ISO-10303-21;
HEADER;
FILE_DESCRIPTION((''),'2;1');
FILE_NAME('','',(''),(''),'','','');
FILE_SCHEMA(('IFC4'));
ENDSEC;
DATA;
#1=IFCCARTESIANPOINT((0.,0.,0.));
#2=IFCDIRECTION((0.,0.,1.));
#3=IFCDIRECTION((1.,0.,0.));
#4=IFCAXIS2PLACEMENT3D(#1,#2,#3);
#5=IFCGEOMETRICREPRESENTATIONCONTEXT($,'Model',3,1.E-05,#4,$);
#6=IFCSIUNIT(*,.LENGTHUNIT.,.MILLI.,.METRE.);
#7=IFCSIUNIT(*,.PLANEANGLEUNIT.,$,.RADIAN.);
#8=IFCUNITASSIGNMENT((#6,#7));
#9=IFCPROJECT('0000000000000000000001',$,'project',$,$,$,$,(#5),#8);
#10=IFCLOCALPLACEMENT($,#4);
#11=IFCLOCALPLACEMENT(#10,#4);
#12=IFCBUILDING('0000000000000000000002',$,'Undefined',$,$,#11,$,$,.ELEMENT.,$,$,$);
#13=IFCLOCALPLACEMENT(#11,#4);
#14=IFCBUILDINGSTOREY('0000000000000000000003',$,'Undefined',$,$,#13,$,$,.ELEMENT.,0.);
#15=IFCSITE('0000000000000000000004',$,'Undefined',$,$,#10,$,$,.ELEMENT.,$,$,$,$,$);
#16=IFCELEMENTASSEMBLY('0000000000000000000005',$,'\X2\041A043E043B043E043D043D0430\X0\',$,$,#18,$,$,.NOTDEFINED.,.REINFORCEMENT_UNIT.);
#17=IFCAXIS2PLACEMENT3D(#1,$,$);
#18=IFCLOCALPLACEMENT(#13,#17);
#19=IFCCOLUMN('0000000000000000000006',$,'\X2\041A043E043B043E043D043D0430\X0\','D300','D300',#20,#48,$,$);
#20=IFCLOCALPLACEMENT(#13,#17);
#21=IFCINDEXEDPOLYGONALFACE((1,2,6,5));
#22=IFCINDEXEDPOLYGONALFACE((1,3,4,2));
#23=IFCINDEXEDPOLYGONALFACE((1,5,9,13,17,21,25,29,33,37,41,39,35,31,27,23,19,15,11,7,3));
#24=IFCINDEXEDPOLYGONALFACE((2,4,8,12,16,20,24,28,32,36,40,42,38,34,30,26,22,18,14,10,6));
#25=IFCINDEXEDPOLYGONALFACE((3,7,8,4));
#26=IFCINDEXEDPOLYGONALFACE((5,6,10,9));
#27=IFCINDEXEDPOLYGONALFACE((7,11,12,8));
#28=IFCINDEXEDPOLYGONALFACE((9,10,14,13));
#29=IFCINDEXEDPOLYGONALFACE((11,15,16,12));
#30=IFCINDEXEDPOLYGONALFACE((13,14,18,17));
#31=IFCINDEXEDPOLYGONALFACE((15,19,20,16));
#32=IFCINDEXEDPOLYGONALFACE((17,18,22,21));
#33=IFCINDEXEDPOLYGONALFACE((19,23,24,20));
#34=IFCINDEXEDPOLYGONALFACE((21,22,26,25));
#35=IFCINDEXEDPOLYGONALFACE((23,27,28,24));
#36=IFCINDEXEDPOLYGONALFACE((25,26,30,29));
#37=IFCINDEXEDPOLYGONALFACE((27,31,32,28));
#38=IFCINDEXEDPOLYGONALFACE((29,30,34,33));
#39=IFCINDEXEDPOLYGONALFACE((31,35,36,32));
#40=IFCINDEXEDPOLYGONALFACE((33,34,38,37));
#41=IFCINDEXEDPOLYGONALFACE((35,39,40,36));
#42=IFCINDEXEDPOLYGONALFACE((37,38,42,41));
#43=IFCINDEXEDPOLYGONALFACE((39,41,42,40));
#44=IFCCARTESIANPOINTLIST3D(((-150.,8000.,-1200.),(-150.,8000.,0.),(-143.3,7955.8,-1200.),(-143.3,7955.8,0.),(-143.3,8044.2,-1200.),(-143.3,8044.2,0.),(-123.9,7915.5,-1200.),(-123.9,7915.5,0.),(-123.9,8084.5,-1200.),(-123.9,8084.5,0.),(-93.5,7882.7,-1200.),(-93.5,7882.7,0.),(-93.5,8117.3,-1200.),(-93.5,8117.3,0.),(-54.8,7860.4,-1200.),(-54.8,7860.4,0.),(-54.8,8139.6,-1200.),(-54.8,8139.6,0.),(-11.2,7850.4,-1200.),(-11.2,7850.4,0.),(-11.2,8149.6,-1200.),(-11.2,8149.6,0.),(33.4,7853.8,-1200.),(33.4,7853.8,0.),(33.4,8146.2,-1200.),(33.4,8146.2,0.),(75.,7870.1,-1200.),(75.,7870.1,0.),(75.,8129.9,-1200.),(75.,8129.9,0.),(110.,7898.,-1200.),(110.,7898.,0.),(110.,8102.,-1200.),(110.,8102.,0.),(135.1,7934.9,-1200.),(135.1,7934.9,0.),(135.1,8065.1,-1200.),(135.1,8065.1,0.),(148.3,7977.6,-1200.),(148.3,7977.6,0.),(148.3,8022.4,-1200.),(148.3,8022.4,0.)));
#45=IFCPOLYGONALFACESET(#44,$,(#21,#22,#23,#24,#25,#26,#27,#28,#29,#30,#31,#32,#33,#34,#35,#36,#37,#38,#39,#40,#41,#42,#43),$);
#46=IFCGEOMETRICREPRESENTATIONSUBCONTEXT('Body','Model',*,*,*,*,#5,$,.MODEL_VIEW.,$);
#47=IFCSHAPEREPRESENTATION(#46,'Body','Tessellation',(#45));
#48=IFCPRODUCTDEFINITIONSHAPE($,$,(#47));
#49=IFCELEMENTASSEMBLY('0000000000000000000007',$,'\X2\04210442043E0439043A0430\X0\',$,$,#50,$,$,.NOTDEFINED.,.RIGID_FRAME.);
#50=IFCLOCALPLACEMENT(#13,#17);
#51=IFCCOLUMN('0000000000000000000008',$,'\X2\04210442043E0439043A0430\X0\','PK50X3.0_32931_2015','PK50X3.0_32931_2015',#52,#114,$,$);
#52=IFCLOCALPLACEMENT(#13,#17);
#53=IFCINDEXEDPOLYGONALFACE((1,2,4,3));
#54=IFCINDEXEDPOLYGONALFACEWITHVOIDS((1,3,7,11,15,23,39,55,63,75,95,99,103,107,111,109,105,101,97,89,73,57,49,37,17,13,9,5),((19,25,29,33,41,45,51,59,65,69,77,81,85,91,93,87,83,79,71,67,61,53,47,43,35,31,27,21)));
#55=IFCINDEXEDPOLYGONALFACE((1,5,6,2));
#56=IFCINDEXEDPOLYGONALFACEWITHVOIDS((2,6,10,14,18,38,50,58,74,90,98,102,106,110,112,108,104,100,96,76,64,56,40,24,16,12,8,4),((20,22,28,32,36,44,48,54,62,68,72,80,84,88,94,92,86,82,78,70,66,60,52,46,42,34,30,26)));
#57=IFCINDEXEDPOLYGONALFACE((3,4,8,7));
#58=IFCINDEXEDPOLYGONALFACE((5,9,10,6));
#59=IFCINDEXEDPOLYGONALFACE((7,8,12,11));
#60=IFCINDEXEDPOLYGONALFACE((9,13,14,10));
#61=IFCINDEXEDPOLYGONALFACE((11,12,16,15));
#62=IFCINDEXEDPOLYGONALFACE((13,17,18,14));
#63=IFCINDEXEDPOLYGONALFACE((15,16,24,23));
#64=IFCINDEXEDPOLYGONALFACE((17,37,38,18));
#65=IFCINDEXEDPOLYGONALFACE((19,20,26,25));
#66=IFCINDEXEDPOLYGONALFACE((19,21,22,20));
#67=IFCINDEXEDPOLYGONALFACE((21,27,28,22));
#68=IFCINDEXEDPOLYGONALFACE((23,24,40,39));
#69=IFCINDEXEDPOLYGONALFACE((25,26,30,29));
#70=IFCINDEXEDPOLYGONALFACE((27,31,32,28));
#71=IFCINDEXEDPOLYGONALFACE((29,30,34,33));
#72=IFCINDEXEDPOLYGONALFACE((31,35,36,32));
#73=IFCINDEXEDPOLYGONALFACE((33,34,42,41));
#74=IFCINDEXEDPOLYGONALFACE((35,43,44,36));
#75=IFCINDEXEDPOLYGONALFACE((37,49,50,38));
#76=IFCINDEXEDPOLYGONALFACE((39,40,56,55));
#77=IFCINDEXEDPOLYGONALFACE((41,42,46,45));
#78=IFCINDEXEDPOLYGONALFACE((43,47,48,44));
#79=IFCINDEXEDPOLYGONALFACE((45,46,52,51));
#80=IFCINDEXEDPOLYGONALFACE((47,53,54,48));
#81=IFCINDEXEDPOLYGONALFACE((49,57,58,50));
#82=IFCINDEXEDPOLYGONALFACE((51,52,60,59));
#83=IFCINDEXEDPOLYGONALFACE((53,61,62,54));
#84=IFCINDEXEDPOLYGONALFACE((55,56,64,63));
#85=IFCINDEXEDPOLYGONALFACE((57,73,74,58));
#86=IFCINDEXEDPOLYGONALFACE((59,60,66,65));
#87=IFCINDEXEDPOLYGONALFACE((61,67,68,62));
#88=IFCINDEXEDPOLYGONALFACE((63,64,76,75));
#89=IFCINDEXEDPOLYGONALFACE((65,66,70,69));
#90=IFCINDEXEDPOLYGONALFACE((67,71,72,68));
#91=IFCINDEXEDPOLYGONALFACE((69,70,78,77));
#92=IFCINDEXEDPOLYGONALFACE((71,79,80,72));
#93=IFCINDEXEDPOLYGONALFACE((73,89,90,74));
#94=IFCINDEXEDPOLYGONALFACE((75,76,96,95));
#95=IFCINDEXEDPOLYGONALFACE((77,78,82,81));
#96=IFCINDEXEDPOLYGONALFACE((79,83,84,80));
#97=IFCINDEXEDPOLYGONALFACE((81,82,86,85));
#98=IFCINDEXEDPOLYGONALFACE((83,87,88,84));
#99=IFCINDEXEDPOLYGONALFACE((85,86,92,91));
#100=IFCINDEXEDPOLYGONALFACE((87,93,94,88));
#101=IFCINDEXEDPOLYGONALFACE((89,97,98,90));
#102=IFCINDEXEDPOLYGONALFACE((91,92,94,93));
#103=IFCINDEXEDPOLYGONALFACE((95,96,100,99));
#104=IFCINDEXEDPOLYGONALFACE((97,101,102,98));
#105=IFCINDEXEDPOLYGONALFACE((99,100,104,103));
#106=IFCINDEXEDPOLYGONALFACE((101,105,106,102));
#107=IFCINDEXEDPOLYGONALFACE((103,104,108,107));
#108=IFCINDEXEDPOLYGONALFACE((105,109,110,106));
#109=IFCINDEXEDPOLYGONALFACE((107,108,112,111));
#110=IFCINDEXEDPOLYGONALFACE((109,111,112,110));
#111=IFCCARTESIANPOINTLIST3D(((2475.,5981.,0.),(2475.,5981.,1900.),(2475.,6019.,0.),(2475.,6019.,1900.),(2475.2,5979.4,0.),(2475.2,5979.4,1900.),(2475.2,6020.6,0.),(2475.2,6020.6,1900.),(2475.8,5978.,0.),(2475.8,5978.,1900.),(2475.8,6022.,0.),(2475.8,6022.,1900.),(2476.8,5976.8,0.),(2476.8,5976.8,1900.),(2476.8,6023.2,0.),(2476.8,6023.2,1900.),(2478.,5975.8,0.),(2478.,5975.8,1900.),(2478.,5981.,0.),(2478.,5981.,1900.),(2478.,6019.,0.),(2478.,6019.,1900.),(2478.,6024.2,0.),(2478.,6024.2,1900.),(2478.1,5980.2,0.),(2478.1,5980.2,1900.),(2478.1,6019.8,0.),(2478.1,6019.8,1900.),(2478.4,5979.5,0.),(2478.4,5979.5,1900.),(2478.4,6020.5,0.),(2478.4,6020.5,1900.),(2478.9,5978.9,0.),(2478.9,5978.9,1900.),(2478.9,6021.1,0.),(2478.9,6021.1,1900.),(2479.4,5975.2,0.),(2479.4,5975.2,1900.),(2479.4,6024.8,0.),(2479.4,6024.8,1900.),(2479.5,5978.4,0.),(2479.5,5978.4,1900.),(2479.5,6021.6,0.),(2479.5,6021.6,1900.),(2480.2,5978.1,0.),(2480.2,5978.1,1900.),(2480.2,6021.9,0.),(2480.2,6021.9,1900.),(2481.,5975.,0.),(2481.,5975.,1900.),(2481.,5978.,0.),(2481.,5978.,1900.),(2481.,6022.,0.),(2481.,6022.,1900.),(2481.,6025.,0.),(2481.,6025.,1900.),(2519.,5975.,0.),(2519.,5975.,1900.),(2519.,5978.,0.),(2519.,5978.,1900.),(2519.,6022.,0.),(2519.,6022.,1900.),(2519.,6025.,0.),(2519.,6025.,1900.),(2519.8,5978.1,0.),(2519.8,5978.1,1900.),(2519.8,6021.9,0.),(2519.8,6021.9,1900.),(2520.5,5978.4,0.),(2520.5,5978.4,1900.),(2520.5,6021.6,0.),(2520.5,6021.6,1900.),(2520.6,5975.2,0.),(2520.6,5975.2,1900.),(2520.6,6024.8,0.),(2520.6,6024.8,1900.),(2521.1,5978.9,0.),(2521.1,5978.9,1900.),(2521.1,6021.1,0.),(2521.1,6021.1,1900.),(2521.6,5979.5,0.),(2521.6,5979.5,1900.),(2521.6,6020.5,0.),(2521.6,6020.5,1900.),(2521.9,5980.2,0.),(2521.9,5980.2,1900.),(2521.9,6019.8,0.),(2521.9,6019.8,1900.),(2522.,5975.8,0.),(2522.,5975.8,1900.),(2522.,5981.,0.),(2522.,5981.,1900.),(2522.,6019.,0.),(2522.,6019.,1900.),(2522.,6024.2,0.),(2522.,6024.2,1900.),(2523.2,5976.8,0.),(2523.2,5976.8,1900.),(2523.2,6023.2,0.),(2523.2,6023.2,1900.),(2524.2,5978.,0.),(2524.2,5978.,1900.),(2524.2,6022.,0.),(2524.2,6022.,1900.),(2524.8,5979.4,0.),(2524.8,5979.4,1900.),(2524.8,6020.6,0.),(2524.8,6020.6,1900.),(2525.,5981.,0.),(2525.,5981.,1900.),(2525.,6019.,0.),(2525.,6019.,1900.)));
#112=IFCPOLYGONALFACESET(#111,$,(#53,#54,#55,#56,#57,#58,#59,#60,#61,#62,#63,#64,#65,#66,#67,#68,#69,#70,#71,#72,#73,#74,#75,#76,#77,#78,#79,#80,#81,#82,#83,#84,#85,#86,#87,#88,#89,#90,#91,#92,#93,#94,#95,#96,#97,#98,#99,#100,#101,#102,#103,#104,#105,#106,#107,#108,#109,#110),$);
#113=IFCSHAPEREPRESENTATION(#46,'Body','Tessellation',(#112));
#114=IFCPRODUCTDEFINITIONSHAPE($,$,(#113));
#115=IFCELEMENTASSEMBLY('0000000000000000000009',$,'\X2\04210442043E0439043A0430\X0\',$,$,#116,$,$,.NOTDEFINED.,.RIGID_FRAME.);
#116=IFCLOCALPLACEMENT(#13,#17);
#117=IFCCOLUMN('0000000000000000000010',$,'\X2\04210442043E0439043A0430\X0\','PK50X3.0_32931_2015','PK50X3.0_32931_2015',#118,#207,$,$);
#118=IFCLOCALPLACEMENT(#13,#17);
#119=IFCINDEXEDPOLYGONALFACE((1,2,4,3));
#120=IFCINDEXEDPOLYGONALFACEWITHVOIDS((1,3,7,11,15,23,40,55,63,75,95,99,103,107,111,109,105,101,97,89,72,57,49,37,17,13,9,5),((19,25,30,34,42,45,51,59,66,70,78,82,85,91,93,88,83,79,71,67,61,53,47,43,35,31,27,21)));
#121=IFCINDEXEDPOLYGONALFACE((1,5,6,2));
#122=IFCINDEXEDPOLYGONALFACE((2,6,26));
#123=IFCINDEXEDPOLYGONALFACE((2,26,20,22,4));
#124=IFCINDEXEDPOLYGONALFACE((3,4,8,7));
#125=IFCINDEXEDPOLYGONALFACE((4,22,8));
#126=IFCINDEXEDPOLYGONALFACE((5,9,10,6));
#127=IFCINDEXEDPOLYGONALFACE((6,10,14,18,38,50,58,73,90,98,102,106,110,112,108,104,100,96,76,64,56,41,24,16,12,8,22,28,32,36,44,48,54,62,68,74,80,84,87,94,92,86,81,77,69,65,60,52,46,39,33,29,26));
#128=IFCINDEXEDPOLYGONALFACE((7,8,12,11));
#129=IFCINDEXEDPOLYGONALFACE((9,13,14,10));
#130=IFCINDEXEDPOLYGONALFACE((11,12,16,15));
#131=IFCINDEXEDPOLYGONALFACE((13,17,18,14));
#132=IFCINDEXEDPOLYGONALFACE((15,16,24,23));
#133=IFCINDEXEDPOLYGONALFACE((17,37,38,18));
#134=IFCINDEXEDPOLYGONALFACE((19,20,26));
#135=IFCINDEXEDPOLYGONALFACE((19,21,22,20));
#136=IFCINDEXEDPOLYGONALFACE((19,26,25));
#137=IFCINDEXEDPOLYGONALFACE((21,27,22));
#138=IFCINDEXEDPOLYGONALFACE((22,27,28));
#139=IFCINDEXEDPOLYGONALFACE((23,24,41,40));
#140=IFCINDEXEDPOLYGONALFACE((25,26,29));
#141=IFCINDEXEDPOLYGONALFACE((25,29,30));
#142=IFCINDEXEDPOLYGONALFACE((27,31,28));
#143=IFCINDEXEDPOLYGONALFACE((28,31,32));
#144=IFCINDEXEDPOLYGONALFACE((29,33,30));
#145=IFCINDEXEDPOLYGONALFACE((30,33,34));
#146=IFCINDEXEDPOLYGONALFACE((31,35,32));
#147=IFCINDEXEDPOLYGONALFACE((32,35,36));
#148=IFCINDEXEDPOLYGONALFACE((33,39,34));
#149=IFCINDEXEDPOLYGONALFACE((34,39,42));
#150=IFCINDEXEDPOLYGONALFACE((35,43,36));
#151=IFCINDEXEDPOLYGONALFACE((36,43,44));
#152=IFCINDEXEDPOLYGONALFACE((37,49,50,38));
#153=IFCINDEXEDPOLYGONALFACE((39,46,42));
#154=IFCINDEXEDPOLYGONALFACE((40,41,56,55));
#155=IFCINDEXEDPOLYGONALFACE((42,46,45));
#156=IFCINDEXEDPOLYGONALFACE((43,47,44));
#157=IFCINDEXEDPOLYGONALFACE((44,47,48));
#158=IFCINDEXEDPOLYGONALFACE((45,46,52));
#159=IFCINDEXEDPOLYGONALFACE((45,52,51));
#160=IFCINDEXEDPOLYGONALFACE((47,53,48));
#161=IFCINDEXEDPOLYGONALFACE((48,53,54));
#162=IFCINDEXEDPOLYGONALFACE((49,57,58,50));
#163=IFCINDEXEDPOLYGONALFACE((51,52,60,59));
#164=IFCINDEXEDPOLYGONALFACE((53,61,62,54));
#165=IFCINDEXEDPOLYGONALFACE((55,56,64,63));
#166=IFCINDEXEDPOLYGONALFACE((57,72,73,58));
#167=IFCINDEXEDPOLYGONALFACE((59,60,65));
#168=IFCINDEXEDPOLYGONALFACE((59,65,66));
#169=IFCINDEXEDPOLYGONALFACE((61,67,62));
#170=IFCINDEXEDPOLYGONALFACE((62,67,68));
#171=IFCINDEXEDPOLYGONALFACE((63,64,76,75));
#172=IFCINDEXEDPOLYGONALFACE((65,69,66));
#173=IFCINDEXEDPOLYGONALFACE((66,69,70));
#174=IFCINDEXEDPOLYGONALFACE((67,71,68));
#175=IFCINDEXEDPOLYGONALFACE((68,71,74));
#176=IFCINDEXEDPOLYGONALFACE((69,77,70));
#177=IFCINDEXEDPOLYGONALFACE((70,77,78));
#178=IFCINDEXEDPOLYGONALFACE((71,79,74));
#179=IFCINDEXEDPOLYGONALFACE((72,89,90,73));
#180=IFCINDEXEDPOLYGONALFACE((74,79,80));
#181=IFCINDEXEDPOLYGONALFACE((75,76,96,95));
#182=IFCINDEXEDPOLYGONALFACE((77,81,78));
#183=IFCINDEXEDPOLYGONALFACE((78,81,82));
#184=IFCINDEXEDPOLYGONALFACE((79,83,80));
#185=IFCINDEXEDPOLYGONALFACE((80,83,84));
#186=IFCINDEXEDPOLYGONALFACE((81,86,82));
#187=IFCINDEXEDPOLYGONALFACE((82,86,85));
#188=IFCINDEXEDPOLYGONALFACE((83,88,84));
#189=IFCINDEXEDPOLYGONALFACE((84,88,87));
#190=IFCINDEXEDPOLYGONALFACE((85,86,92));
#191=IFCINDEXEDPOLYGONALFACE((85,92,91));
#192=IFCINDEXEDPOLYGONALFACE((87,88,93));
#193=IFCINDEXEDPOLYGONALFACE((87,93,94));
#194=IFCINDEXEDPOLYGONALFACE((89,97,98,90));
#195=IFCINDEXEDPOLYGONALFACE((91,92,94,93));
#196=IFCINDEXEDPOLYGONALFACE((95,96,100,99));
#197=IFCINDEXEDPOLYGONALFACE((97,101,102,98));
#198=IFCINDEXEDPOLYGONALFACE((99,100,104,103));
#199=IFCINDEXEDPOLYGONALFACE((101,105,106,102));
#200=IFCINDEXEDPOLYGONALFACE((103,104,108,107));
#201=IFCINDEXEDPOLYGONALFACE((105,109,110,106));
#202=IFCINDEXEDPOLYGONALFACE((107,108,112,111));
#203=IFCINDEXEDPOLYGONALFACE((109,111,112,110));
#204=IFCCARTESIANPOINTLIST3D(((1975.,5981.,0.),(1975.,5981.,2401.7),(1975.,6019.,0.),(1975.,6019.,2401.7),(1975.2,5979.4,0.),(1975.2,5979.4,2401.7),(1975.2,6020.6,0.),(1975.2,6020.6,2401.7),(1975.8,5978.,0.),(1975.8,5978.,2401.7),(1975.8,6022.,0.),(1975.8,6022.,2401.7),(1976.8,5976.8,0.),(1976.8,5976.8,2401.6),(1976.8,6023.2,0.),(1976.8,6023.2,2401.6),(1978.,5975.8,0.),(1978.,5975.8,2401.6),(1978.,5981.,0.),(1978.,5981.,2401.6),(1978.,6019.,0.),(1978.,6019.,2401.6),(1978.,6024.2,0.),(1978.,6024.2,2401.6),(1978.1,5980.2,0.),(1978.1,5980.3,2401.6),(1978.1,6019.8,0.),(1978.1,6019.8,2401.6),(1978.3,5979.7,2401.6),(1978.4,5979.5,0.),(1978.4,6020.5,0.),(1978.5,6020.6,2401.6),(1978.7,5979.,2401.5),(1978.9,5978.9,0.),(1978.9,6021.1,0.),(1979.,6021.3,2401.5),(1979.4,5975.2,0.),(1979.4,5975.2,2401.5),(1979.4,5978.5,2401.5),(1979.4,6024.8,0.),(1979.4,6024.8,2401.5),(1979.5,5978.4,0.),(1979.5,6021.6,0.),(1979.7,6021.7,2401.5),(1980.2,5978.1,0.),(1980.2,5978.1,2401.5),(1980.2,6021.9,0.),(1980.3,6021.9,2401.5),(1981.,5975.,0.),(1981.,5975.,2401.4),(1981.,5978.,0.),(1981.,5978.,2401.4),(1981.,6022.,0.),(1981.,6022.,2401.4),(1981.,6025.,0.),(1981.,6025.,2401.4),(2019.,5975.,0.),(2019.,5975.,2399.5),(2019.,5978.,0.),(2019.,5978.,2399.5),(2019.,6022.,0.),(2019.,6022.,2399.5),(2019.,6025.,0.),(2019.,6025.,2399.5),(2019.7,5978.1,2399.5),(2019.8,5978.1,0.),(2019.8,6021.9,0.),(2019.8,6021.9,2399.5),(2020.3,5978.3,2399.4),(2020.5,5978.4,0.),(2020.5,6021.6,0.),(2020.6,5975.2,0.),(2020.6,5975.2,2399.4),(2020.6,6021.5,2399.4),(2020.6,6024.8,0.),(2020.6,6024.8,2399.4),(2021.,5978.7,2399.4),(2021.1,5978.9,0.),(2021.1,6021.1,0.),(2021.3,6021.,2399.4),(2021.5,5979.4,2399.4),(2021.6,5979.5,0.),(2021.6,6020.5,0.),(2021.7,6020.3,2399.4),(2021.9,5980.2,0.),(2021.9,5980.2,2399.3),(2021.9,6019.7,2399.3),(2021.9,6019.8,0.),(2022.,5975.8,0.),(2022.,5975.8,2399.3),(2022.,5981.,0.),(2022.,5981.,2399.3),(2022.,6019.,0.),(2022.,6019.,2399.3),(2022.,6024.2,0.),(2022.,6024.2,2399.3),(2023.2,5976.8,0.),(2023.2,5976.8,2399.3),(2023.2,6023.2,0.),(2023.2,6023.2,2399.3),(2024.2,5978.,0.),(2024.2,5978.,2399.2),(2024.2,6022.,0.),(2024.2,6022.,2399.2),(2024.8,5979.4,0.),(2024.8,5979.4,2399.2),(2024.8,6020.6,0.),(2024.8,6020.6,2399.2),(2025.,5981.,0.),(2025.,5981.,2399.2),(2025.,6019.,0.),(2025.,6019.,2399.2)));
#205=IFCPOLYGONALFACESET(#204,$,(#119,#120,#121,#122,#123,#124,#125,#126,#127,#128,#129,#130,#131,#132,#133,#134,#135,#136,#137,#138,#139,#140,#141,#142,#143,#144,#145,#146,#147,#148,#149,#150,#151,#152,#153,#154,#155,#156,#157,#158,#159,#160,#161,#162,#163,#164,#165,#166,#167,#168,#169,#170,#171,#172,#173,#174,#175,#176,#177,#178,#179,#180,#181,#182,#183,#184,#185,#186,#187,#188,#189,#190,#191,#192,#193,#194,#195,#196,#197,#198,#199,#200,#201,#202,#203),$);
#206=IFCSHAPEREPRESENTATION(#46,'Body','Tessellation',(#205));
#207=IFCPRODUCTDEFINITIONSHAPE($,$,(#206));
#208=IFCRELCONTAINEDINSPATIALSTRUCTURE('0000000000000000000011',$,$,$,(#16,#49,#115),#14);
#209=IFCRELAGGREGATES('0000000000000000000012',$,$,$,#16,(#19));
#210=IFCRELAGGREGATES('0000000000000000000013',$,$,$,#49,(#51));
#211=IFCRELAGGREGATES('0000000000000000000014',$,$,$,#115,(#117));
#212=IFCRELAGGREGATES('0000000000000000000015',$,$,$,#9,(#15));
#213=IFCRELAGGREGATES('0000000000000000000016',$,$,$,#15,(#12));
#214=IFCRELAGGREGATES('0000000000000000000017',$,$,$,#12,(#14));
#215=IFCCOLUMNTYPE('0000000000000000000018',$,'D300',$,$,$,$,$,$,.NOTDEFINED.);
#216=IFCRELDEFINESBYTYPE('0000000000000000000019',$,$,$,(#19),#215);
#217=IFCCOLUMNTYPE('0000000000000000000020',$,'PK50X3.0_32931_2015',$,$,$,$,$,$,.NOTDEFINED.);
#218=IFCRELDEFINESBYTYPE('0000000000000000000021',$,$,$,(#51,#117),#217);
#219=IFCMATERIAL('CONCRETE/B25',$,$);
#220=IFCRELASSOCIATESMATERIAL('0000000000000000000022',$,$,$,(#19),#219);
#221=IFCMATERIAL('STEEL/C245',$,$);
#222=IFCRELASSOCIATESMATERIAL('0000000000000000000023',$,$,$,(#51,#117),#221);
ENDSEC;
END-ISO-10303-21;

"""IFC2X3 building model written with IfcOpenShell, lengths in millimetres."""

from ifc_helpers import new_model, si_unit, frame, origin_with_axes, origin_2d_with_axis, place, context, subcontext, project, spatial, hollow_rectangle, circle, extrude, clip, halfspace, material, type_object, element, aggregate, save


model = new_model("IFC2X3")

# Units and contexts
model_context = context("Model", 3, precision=1e-05, world=origin_with_axes())
body_context = subcontext(model_context, "Body", "Model", "MODEL_VIEW")
ifc_project = project(units=[si_unit("LENGTHUNIT", "METRE", prefix="MILLI"), si_unit("PLANEANGLEUNIT", "RADIAN")], contexts=[model_context])

# Site, building, storey
site_placement = place(None, origin_with_axes())
site = spatial("IfcSite", under=ifc_project, at=site_placement, Name="Undefined", CompositionType="ELEMENT")
building_placement = place(site_placement, origin_with_axes())
building = spatial("IfcBuilding", under=site, at=building_placement, Name="Undefined", CompositionType="ELEMENT")
storey_placement = place(building_placement, origin_with_axes())
storey = spatial("IfcBuildingStorey", under=building, at=storey_placement, Name="Undefined", CompositionType="ELEMENT", Elevation=0.0)

# Element assemblies, columns
assembly_1_placement = place(storey_placement, origin_with_axes())
assembly_1 = element("IfcElementAssembly", 1, at=assembly_1_placement, inside=storey, Name="Колонна", AssemblyPlace="NOTDEFINED", PredefinedType="REINFORCEMENT_UNIT")
ifc_material_1 = material(Name="CONCRETE/B25")
column_type_1 = type_object("IfcColumnType", Name="D300", PredefinedType="NOTDEFINED")
column_1_placement = place(assembly_1_placement, frame((0.0, 8000.0, -1200.0), z_axis=(0.0, 0.0, 1.0), x_axis=(0.0, 1.0, 0.0)))
column_1 = element("IfcColumn", 2, at=column_1_placement, type_object=column_type_1, material=ifc_material_1, Name="Колонна", Description="D300", ObjectType="D300", context=body_context, shape_type="SweptSolid", body=[
    extrude(circle(Radius=150.0, at=origin_2d_with_axis()), frame((0.0, 0.0, 1200.0), z_axis=(0.0, 0.0, -1.0), x_axis=(0.0, 1.0, 0.0)), (0.0, 0.0, 1.0), 1200.0),
])
aggregate(assembly_1, [column_1])
assembly_2_placement = place(storey_placement, origin_with_axes())
assembly_2 = element("IfcElementAssembly", 3, at=assembly_2_placement, inside=storey, Name="Стойка", AssemblyPlace="NOTDEFINED", PredefinedType="RIGID_FRAME")
ifc_material_2 = material(Name="STEEL/C245")
column_type_2 = type_object("IfcColumnType", Name="PK50X3.0_32931_2015", PredefinedType="NOTDEFINED")
column_2_placement = place(assembly_2_placement, frame((2500.0, 6000.0, 0.0), z_axis=(0.0, 0.0, 1.0), x_axis=(0.0, 1.0, 0.0)))
column_2 = element("IfcColumn", 4, at=column_2_placement, type_object=column_type_2, material=ifc_material_2, Name="Стойка", Description="PK50X3.0_32931_2015", ObjectType="PK50X3.0_32931_2015", context=body_context, shape_type="Clipping", body=[
    clip(extrude(hollow_rectangle(XDim=50.0, YDim=50.0, WallThickness=3.0, InnerFilletRadius=3.0, OuterFilletRadius=6.0, at=origin_2d_with_axis()), frame((0.0, 0.0, 1900.0), z_axis=(0.0, 0.0, -1.0), x_axis=(0.0, 1.0, 0.0)), (0.0, 0.0, 1.0), 1900.0), halfspace(frame((0.0, -135.2, 1900.0), z_axis=(0.0, 0.0, -1.0), x_axis=(-1.0, 0.0, 0.0)), True)),
])
aggregate(assembly_2, [column_2])
assembly_3_placement = place(storey_placement, origin_with_axes())
assembly_3 = element("IfcElementAssembly", 5, at=assembly_3_placement, inside=storey, Name="Стойка", AssemblyPlace="NOTDEFINED", PredefinedType="RIGID_FRAME")
column_3_placement = place(assembly_3_placement, frame((2000.0, 6000.0, 0.0), z_axis=(0.0, 0.0, 1.0), x_axis=(0.0, 1.0, 0.0)))
column_3 = element("IfcColumn", 6, at=column_3_placement, type_object=column_type_2, material=ifc_material_2, Name="Стойка", Description="PK50X3.0_32931_2015", ObjectType="PK50X3.0_32931_2015", context=body_context, shape_type="Clipping", body=[
    clip(extrude(hollow_rectangle(XDim=50.0, YDim=50.0, WallThickness=3.0, InnerFilletRadius=3.0, OuterFilletRadius=6.0, at=origin_2d_with_axis()), frame((0.0, 0.0, 2401.7), z_axis=(0.0, 0.0, -1.0), x_axis=(0.0, 1.0, 0.0)), (0.0, 0.0, 1.0), 2401.7), halfspace(frame((0.0, -2147.1, 2291.3), z_axis=(0.0, 0.050782, -0.99871), x_axis=(-1.0, 0.0, 0.0)), True)),
])
aggregate(assembly_3, [column_3])

save(model, "model.ifc")
